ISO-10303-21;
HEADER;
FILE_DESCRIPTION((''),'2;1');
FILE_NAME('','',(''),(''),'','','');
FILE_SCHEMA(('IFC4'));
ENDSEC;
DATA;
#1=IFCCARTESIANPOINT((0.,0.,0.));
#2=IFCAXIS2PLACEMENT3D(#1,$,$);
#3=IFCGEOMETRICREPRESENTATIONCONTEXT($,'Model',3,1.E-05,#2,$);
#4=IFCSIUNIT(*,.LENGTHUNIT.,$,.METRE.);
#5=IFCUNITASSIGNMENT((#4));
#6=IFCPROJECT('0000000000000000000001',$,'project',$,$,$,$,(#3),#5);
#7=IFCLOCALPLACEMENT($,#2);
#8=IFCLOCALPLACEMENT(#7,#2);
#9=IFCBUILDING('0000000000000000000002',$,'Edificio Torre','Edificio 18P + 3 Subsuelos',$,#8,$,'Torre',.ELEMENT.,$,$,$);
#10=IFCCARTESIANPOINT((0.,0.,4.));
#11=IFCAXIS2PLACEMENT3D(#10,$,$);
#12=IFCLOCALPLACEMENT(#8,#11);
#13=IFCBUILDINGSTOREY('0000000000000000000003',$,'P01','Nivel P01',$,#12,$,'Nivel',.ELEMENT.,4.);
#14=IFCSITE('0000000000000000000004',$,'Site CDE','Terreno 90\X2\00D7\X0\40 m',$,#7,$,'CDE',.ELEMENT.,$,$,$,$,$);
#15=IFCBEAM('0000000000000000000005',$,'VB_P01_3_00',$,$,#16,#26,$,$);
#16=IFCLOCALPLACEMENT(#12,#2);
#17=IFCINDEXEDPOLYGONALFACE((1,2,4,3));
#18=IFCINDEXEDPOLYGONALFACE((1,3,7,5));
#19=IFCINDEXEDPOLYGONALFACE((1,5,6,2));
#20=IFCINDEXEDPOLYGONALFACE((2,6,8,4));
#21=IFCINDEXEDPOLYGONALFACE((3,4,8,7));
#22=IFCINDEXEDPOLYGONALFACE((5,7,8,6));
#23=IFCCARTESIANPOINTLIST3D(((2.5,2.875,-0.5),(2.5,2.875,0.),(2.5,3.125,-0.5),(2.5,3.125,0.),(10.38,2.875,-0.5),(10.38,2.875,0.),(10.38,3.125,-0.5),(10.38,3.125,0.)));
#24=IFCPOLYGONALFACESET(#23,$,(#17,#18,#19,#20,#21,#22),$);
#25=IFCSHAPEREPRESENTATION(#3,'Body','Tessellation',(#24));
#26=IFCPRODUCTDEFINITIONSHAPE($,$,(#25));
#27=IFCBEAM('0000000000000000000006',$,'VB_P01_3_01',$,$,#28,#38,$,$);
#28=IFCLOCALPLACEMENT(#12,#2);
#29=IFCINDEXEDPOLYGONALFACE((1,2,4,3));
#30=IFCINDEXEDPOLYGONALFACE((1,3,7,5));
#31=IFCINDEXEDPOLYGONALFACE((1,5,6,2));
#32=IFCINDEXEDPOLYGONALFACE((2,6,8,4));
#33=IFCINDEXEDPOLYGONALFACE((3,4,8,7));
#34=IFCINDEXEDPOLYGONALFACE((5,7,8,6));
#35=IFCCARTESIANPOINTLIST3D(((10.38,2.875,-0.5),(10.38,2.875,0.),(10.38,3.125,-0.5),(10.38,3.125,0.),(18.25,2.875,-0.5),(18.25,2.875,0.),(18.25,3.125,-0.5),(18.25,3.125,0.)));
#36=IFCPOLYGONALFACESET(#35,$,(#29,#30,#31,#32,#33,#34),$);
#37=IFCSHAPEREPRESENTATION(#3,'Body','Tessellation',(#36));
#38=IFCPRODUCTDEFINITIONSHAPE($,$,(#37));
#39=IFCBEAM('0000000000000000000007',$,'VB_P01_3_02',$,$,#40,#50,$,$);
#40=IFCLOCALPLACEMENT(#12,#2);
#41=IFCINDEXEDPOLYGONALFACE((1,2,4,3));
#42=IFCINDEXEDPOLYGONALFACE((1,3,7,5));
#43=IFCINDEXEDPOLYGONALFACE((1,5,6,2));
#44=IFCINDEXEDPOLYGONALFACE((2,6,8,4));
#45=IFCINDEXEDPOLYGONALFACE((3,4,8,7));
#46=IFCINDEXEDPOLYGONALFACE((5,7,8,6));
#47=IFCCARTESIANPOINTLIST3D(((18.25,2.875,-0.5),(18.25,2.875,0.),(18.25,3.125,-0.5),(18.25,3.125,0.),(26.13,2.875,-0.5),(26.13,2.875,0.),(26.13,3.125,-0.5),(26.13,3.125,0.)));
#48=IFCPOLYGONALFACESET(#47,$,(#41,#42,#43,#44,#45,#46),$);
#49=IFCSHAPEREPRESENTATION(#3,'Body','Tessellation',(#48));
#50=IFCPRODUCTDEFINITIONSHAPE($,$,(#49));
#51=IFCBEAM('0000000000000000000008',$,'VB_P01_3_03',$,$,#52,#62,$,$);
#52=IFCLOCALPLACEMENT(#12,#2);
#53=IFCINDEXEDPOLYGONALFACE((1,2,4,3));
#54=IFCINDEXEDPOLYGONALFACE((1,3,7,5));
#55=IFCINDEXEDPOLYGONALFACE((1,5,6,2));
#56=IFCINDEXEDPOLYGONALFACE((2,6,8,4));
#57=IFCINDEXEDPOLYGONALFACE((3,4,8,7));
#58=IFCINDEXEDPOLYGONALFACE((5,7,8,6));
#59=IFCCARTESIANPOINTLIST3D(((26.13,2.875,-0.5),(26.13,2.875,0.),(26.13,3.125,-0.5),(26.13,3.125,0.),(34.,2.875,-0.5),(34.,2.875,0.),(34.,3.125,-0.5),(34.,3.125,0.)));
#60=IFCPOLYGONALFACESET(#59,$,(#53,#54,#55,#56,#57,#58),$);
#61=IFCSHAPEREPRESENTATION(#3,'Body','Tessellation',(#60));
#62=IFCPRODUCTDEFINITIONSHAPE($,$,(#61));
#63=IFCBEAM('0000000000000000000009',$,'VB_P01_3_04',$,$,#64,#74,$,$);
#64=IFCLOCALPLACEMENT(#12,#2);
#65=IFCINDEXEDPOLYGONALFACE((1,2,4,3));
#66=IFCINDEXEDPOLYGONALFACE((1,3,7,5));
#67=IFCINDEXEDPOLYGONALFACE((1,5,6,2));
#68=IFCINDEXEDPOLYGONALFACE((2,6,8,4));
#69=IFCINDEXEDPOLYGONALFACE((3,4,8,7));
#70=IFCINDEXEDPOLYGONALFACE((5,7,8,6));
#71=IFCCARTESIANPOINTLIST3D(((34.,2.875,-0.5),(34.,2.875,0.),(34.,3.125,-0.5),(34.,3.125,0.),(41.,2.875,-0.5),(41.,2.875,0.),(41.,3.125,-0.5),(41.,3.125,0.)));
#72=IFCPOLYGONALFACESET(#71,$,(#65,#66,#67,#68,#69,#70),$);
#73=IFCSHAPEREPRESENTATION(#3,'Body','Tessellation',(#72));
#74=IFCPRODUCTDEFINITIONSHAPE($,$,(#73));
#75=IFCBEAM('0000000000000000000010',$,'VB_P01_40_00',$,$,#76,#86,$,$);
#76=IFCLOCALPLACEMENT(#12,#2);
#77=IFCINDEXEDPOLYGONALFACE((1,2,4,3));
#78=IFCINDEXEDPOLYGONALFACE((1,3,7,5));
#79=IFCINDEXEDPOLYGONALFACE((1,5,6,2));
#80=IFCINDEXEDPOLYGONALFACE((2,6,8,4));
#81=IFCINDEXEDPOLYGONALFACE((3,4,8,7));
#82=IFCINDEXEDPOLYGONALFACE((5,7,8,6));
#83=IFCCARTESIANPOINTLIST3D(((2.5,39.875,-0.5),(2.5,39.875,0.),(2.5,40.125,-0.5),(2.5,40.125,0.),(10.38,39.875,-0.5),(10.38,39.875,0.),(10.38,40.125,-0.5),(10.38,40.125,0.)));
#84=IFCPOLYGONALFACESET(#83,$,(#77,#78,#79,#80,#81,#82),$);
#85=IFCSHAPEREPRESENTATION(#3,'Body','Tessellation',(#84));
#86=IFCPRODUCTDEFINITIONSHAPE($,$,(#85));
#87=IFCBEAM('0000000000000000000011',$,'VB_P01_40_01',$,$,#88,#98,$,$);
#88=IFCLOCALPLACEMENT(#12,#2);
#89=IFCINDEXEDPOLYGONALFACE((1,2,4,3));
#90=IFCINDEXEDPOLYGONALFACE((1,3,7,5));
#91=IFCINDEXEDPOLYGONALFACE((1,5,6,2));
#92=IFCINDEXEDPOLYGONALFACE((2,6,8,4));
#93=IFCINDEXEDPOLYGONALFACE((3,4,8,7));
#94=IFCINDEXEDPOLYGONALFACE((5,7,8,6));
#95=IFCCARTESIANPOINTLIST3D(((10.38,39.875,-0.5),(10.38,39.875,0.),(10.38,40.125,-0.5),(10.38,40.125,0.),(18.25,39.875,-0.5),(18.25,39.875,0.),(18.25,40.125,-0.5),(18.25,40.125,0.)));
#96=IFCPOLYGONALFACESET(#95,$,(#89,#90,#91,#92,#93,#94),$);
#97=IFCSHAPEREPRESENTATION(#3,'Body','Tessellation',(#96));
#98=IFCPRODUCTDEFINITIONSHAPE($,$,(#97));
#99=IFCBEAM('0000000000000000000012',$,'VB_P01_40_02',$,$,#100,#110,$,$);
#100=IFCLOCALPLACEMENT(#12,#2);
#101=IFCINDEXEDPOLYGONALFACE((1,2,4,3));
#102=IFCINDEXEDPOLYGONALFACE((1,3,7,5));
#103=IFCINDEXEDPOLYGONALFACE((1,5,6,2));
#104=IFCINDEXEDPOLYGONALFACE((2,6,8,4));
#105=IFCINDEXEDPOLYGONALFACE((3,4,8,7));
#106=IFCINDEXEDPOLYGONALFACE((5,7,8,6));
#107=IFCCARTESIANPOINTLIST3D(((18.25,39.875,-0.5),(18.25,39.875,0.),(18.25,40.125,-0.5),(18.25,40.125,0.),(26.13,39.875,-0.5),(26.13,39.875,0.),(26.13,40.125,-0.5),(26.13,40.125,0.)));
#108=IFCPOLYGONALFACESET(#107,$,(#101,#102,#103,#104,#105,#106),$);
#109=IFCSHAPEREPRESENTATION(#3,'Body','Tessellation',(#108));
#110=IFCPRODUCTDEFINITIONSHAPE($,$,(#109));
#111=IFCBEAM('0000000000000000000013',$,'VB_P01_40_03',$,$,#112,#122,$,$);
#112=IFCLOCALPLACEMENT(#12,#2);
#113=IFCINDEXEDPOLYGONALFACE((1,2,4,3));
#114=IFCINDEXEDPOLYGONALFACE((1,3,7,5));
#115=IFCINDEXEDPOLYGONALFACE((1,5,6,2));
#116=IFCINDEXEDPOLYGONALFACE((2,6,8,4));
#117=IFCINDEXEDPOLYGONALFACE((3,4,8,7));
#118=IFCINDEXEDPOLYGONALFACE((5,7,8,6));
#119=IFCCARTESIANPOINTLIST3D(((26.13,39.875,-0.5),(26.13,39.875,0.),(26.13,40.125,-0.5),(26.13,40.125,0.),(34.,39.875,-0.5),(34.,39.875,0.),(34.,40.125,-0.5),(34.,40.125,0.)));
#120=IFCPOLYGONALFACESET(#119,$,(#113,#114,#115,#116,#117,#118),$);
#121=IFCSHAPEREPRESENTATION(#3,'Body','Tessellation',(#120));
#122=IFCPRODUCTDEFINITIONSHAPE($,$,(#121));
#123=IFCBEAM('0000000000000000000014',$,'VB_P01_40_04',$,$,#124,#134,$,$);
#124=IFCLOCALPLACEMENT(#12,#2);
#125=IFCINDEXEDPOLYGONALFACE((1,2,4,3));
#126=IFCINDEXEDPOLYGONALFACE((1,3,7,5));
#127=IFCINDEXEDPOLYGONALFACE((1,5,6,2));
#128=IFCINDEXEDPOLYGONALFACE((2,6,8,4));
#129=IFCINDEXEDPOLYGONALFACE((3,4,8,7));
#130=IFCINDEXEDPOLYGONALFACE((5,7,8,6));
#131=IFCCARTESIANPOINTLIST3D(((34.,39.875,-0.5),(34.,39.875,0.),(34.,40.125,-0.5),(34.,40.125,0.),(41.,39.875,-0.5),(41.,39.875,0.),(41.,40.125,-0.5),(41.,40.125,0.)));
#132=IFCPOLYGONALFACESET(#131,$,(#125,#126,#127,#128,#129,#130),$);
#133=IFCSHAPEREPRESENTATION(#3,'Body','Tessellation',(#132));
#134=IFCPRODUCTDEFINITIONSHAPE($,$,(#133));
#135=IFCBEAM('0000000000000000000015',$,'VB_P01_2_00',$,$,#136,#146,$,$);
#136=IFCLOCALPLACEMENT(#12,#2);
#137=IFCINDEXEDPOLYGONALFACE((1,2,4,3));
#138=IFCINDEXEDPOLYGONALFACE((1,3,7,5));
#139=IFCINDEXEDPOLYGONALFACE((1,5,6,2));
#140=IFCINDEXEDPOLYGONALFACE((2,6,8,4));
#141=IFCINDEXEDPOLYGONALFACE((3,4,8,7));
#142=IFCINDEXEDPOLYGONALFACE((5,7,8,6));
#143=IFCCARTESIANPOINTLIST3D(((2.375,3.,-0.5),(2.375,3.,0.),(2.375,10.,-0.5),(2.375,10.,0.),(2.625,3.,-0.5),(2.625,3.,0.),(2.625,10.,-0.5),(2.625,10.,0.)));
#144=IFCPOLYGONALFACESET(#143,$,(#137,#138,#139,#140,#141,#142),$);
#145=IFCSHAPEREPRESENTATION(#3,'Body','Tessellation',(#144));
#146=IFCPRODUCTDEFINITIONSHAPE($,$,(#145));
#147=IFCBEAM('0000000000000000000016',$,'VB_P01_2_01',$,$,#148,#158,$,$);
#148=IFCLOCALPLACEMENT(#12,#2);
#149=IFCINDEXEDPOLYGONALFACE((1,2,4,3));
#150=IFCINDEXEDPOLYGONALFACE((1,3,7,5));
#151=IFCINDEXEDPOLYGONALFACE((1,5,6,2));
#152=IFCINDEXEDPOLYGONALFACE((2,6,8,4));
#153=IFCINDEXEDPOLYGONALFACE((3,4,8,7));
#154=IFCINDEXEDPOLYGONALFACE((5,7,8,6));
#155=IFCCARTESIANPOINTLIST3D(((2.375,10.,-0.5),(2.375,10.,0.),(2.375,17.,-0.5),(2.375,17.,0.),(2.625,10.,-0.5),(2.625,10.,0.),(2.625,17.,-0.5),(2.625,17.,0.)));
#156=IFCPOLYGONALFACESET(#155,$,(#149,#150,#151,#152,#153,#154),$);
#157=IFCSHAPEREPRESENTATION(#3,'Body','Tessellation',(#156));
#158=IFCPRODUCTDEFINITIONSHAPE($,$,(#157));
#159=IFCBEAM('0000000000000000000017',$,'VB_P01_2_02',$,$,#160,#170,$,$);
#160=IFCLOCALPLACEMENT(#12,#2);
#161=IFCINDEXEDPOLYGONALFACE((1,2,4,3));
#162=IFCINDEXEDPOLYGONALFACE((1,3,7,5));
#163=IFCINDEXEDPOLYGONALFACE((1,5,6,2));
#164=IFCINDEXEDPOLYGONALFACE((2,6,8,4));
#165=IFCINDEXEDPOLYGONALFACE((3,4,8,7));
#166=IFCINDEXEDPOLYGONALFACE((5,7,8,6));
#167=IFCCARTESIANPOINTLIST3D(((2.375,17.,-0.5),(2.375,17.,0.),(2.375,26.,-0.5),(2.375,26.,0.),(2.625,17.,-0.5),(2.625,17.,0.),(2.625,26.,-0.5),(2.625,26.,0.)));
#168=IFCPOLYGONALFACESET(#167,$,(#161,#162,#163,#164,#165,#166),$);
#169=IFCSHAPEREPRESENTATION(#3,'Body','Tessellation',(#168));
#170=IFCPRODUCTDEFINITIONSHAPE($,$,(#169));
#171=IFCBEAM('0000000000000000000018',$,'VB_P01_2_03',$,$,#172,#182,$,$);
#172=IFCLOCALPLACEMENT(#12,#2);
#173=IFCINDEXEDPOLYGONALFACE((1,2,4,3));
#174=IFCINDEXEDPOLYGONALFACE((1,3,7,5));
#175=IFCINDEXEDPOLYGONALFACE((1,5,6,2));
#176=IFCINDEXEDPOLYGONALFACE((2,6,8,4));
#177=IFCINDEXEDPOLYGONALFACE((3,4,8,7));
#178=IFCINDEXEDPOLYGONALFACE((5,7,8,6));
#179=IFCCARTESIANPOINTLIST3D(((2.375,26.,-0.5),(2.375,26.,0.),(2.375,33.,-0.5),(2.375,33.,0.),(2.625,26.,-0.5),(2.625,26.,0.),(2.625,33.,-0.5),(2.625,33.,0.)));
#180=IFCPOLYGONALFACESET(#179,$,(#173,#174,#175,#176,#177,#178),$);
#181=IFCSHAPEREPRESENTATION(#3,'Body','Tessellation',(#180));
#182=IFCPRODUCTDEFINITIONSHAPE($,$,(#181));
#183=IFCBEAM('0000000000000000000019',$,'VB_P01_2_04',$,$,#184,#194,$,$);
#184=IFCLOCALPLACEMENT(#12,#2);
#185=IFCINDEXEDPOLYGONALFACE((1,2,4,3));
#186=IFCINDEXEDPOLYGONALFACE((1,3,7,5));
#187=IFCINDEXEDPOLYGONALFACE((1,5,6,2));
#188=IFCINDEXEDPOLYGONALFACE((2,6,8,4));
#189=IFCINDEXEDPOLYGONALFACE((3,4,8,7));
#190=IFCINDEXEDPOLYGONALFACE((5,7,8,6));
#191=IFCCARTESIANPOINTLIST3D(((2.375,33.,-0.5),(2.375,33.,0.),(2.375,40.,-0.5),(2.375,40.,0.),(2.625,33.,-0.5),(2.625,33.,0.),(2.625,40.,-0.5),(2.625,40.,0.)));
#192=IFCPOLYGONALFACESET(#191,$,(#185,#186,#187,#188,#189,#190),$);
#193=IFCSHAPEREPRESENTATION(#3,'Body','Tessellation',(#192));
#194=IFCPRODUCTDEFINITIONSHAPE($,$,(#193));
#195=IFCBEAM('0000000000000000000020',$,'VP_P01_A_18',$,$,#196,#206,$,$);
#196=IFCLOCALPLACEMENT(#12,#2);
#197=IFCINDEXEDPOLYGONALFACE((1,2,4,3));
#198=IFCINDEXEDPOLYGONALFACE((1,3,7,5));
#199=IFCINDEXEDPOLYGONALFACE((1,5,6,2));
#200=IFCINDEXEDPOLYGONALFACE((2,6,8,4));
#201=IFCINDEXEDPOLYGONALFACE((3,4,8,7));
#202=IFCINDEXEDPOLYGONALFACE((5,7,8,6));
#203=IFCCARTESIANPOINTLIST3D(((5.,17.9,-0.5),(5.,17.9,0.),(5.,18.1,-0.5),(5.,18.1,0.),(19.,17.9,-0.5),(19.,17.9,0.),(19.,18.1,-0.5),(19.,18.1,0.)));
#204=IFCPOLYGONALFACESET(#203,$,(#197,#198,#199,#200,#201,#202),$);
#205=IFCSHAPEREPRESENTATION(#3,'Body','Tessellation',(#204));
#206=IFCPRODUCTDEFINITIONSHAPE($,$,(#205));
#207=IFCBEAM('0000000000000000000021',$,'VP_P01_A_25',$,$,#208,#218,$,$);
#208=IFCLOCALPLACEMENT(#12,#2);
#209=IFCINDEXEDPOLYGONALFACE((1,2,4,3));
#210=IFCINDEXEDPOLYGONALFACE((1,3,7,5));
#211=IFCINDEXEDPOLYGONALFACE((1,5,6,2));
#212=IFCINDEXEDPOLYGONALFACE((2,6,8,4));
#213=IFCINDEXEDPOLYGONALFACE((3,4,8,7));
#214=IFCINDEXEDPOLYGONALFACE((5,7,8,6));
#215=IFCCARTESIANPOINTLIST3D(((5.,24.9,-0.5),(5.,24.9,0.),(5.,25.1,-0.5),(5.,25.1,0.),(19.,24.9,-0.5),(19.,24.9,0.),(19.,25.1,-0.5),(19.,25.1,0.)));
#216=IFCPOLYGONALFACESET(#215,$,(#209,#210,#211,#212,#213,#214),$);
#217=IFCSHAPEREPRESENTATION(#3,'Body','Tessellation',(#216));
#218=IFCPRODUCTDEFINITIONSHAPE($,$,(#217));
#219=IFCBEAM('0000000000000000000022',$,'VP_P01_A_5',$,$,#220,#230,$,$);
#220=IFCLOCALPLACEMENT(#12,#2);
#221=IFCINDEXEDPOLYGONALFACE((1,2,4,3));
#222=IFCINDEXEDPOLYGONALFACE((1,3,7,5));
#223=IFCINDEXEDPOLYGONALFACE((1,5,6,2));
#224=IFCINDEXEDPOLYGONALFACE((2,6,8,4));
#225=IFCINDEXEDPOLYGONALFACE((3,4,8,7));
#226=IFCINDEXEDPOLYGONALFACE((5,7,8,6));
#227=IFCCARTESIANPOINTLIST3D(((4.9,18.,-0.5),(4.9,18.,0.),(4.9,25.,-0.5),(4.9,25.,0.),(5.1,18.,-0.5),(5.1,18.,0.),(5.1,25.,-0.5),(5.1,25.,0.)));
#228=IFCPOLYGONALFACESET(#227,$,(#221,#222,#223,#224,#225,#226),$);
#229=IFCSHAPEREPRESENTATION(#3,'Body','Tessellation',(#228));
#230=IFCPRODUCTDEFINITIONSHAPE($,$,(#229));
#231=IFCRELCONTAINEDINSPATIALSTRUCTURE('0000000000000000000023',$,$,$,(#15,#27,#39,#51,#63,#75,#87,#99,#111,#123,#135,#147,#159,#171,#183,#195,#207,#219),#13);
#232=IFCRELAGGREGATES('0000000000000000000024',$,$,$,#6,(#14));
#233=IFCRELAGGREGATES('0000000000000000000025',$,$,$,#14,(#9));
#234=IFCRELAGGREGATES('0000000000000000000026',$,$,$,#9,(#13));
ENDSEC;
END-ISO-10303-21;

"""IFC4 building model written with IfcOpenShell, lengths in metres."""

from ifc_helpers import new_model, si_unit, frame, origin, origin_2d, place, context, project, spatial, rectangle, extrude, element, save


model = new_model("IFC4")

# Units and contexts
model_context = context("Model", 3, precision=1e-05, world=origin())
ifc_project = project(units=[si_unit("LENGTHUNIT", "METRE")], contexts=[model_context])

# Site, building, storey
site_placement = place(None, origin())
site = spatial("IfcSite", under=ifc_project, at=site_placement, Name="Site CDE", Description="Terreno 90×40 m", LongName="CDE", CompositionType="ELEMENT")
building_placement = place(site_placement, origin())
building = spatial("IfcBuilding", under=site, at=building_placement, Name="Edificio Torre", Description="Edificio 18P + 3 Subsuelos", LongName="Torre", CompositionType="ELEMENT")
storey_placement = place(building_placement, frame((0.0, 0.0, 4.0)))
storey = spatial("IfcBuildingStorey", under=building, at=storey_placement, Name="P01", Description="Nivel P01", LongName="Nivel", CompositionType="ELEMENT", Elevation=4.0)

# Beams
beam_1_placement = place(storey_placement, frame((6.44, 3.0, -0.5)))
element("IfcBeam", 1, at=beam_1_placement, inside=storey, Name="VB_P01_3_00", context=model_context, shape_type="SweptSolid", body=[
    extrude(rectangle(XDim=7.88, YDim=0.25, at=origin_2d()), origin(), (0.0, 0.0, 1.0), 0.5),
])
beam_2_placement = place(storey_placement, frame((14.315, 3.0, -0.5)))
element("IfcBeam", 2, at=beam_2_placement, inside=storey, Name="VB_P01_3_01", context=model_context, shape_type="SweptSolid", body=[
    extrude(rectangle(XDim=7.87, YDim=0.25, at=origin_2d()), origin(), (0.0, 0.0, 1.0), 0.5),
])
beam_3_placement = place(storey_placement, frame((22.19, 3.0, -0.5)))
element("IfcBeam", 3, at=beam_3_placement, inside=storey, Name="VB_P01_3_02", context=model_context, shape_type="SweptSolid", body=[
    extrude(rectangle(XDim=7.88, YDim=0.25, at=origin_2d()), origin(), (0.0, 0.0, 1.0), 0.5),
])
beam_4_placement = place(storey_placement, frame((30.065, 3.0, -0.5)))
element("IfcBeam", 4, at=beam_4_placement, inside=storey, Name="VB_P01_3_03", context=model_context, shape_type="SweptSolid", body=[
    extrude(rectangle(XDim=7.87, YDim=0.25, at=origin_2d()), origin(), (0.0, 0.0, 1.0), 0.5),
])
beam_5_placement = place(storey_placement, frame((37.5, 3.0, -0.5)))
element("IfcBeam", 5, at=beam_5_placement, inside=storey, Name="VB_P01_3_04", context=model_context, shape_type="SweptSolid", body=[
    extrude(rectangle(XDim=7.0, YDim=0.25, at=origin_2d()), origin(), (0.0, 0.0, 1.0), 0.5),
])
beam_6_placement = place(storey_placement, frame((6.44, 40.0, -0.5)))
element("IfcBeam", 6, at=beam_6_placement, inside=storey, Name="VB_P01_40_00", context=model_context, shape_type="SweptSolid", body=[
    extrude(rectangle(XDim=7.88, YDim=0.25, at=origin_2d()), origin(), (0.0, 0.0, 1.0), 0.5),
])
beam_7_placement = place(storey_placement, frame((14.315, 40.0, -0.5)))
element("IfcBeam", 7, at=beam_7_placement, inside=storey, Name="VB_P01_40_01", context=model_context, shape_type="SweptSolid", body=[
    extrude(rectangle(XDim=7.87, YDim=0.25, at=origin_2d()), origin(), (0.0, 0.0, 1.0), 0.5),
])
beam_8_placement = place(storey_placement, frame((22.19, 40.0, -0.5)))
element("IfcBeam", 8, at=beam_8_placement, inside=storey, Name="VB_P01_40_02", context=model_context, shape_type="SweptSolid", body=[
    extrude(rectangle(XDim=7.88, YDim=0.25, at=origin_2d()), origin(), (0.0, 0.0, 1.0), 0.5),
])
beam_9_placement = place(storey_placement, frame((30.065, 40.0, -0.5)))
element("IfcBeam", 9, at=beam_9_placement, inside=storey, Name="VB_P01_40_03", context=model_context, shape_type="SweptSolid", body=[
    extrude(rectangle(XDim=7.87, YDim=0.25, at=origin_2d()), origin(), (0.0, 0.0, 1.0), 0.5),
])
beam_10_placement = place(storey_placement, frame((37.5, 40.0, -0.5)))
element("IfcBeam", 10, at=beam_10_placement, inside=storey, Name="VB_P01_40_04", context=model_context, shape_type="SweptSolid", body=[
    extrude(rectangle(XDim=7.0, YDim=0.25, at=origin_2d()), origin(), (0.0, 0.0, 1.0), 0.5),
])
for number, where, name in (
    (11, (2.5, 6.5, -0.5), "VB_P01_2_00"),
    (12, (2.5, 13.5, -0.5), "VB_P01_2_01"),
):
    element("IfcBeam", number, at=place(storey_placement, frame(where)), inside=storey, Name=name, context=model_context, shape_type="SweptSolid", body=[
        extrude(rectangle(XDim=0.25, YDim=7.0, at=origin_2d()), origin(), (0.0, 0.0, 1.0), 0.5),
    ])
beam_11_placement = place(storey_placement, frame((2.5, 21.5, -0.5)))
element("IfcBeam", 13, at=beam_11_placement, inside=storey, Name="VB_P01_2_02", context=model_context, shape_type="SweptSolid", body=[
    extrude(rectangle(XDim=0.25, YDim=9.0, at=origin_2d()), origin(), (0.0, 0.0, 1.0), 0.5),
])
for number, where, name in (
    (14, (2.5, 29.5, -0.5), "VB_P01_2_03"),
    (15, (2.5, 36.5, -0.5), "VB_P01_2_04"),
):
    element("IfcBeam", number, at=place(storey_placement, frame(where)), inside=storey, Name=name, context=model_context, shape_type="SweptSolid", body=[
        extrude(rectangle(XDim=0.25, YDim=7.0, at=origin_2d()), origin(), (0.0, 0.0, 1.0), 0.5),
    ])
for number, where, name in (
    (16, (12.0, 18.0, -0.5), "VP_P01_A_18"),
    (17, (12.0, 25.0, -0.5), "VP_P01_A_25"),
):
    element("IfcBeam", number, at=place(storey_placement, frame(where)), inside=storey, Name=name, context=model_context, shape_type="SweptSolid", body=[
        extrude(rectangle(XDim=14.0, YDim=0.2, at=origin_2d()), origin(), (0.0, 0.0, 1.0), 0.5),
    ])
beam_12_placement = place(storey_placement, frame((5.0, 21.5, -0.5)))
element("IfcBeam", 18, at=beam_12_placement, inside=storey, Name="VP_P01_A_5", context=model_context, shape_type="SweptSolid", body=[
    extrude(rectangle(XDim=0.2, YDim=7.0, at=origin_2d()), origin(), (0.0, 0.0, 1.0), 0.5),
])

save(model, "model.ifc")
